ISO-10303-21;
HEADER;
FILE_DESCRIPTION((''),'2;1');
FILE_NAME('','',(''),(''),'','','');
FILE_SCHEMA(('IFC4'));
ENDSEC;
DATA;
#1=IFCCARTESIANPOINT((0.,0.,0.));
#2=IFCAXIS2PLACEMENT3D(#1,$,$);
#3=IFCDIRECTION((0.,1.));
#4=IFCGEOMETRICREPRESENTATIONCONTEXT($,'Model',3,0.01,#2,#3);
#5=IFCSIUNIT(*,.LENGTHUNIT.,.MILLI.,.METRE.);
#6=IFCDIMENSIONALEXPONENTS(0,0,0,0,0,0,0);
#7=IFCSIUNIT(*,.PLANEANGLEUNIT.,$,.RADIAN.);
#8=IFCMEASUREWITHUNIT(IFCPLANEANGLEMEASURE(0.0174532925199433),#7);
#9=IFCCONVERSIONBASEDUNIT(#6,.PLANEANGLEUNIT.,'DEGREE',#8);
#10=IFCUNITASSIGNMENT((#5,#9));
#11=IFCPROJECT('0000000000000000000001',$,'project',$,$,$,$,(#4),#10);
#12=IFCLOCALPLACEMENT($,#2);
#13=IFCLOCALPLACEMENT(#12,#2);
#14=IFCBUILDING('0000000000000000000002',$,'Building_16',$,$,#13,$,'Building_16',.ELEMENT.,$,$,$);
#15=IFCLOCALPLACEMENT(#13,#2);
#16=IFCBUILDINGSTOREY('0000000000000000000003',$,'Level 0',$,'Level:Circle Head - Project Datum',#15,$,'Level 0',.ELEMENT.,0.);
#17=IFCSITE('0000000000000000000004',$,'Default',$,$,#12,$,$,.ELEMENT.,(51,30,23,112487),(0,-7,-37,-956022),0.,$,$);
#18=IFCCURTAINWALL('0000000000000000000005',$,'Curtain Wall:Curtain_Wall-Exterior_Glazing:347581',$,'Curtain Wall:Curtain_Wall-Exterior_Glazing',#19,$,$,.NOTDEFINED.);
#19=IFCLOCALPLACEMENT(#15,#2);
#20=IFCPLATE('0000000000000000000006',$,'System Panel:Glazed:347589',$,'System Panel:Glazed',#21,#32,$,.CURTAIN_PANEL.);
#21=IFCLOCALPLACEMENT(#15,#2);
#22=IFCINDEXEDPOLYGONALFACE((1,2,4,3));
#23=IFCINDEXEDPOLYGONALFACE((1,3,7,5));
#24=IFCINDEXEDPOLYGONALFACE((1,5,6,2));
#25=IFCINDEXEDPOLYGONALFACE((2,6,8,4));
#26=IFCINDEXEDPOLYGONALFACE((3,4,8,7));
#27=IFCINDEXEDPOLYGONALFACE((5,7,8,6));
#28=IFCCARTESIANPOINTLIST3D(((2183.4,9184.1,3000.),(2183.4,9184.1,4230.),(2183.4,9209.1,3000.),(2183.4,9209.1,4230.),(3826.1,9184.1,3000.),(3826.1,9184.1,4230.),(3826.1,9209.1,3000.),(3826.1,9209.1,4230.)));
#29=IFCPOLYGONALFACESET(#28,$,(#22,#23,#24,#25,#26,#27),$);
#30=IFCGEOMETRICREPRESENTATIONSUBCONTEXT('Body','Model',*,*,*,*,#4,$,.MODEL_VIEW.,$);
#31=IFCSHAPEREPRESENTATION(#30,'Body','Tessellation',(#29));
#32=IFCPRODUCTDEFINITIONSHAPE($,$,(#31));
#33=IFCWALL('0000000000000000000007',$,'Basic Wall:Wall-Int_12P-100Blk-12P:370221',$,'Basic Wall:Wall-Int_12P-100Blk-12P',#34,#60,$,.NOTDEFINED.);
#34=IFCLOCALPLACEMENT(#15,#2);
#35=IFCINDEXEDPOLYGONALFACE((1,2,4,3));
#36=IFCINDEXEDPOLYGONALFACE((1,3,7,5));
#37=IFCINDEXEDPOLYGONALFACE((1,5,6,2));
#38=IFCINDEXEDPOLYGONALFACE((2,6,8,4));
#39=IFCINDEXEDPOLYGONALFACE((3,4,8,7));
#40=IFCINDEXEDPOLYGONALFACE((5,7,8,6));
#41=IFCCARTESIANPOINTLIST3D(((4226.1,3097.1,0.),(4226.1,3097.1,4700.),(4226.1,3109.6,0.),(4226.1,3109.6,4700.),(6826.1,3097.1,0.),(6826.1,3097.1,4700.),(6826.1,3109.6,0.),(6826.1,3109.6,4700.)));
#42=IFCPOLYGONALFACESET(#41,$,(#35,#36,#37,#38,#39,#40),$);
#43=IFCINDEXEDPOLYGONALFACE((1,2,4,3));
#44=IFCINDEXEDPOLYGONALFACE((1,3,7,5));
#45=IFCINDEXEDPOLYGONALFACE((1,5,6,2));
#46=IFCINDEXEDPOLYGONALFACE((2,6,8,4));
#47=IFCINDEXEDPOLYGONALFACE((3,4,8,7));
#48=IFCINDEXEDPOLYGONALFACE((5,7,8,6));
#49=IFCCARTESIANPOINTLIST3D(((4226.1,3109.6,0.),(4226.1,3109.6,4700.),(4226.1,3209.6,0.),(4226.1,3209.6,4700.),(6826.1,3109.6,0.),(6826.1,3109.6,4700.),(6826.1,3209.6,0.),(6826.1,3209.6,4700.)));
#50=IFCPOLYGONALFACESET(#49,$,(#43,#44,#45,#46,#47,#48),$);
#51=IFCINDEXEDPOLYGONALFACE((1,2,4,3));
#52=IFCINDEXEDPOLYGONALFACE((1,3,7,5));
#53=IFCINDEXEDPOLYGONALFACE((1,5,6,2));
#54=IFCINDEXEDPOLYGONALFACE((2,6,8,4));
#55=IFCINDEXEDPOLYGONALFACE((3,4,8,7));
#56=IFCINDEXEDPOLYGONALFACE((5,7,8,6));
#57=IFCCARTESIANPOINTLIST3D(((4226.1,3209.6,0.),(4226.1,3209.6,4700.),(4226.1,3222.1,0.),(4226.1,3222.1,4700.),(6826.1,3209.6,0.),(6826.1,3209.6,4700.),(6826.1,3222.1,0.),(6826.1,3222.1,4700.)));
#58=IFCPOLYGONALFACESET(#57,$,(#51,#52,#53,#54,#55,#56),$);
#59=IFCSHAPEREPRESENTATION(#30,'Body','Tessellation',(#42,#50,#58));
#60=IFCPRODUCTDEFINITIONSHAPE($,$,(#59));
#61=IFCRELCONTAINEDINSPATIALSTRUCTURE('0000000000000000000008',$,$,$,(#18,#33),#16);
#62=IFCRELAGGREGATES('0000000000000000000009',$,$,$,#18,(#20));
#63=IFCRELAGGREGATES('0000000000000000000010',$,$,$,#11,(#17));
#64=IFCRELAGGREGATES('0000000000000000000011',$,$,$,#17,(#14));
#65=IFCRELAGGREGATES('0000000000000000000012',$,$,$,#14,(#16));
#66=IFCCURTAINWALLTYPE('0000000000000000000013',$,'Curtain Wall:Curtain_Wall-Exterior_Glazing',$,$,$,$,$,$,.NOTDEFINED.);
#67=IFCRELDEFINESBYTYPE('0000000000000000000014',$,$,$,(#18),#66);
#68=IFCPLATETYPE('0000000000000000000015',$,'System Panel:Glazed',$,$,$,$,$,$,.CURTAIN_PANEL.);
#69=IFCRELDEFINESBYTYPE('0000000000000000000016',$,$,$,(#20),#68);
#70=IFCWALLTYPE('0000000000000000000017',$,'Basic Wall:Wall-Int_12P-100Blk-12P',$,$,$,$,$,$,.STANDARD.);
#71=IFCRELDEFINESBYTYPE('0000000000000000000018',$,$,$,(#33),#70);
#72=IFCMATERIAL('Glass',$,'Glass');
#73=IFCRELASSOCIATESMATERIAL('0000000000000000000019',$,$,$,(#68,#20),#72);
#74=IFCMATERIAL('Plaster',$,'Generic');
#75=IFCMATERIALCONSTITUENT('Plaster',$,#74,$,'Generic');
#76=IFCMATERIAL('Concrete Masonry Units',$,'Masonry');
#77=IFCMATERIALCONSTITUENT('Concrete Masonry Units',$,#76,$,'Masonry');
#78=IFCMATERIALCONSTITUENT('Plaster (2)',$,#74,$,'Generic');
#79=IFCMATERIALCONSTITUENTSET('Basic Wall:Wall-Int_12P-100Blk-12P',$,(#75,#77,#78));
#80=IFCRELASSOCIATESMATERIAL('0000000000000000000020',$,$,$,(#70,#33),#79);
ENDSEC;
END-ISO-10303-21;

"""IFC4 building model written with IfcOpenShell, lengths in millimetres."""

from ifc_helpers import new_model, entity, si_unit, converted_unit, direction, frame, origin, place, context, subcontext, project, spatial, indexed_curve, outline, extrude, source, transform, mapped, material, constituent, constituent_set, type_object, type_shapes, element, aggregate, save


model = new_model("IFC4")

# Units and contexts
model_context = context("Model", 3, precision=0.01, world=origin(), true_north=direction((0.0, 1.0)))
body_context = subcontext(model_context, "Body", "Model", "MODEL_VIEW")
ifc_project = project(units=[si_unit("LENGTHUNIT", "METRE", prefix="MILLI"), converted_unit("PLANEANGLEUNIT", "DEGREE", entity("IfcPlaneAngleMeasure", 0.0174532925199433), si_unit("PLANEANGLEUNIT", "RADIAN"), dimensions=[0, 0, 0, 0, 0, 0, 0])], contexts=[model_context])

# Site, building, storey
site_placement = place(None, origin())
site = spatial("IfcSite", under=ifc_project, at=site_placement, Name="Default", CompositionType="ELEMENT", RefLatitude=(51, 30, 23, 112487), RefLongitude=(0, -7, -37, -956022), RefElevation=0.0)
building_placement = place(site_placement, origin())
building = spatial("IfcBuilding", under=site, at=building_placement, Name="Building_16", LongName="Building_16", CompositionType="ELEMENT")
storey_placement = place(building_placement, origin())
storey = spatial("IfcBuildingStorey", under=building, at=storey_placement, Name="Level 0", ObjectType="Level:Circle Head - Project Datum", LongName="Level 0", CompositionType="ELEMENT", Elevation=0.0)

# Shared definitions
curtain_wall_type = type_object("IfcCurtainWallType", Name="Curtain Wall:Curtain_Wall-Exterior_Glazing", PredefinedType="NOTDEFINED")
ifc_material_1 = material(Name="Glass", Category="Glass")

# Curtain wall, plate
curtain_wall_1_placement = place(storey_placement, origin())
curtain_wall_1 = element("IfcCurtainWall", 1, at=curtain_wall_1_placement, inside=storey, type_object=curtain_wall_type, Name="Curtain Wall:Curtain_Wall-Exterior_Glazing:347581", ObjectType="Curtain Wall:Curtain_Wall-Exterior_Glazing", PredefinedType="NOTDEFINED")
plate_type_1 = type_object("IfcPlateType", Name="System Panel:Glazed", PredefinedType="CURTAIN_PANEL", material=ifc_material_1)
shared_shape_1 = source(origin(), body_context, "Body", "SweptSolid", [
    extrude(outline(indexed_curve([(-12.5, -821.4), (12.5, -821.4), (12.5, 821.4), (-12.5, 821.4), (-12.5, -821.4)], self_intersect=False)), frame((0.0, 37.0, 0.0), z_axis=(0.0, 0.0, 1.0), x_axis=(0.0, 1.0, 0.0)), (0.0, 0.0, 1.0), 1230.0),
])
type_shapes(plate_type_1, [shared_shape_1])
plate_1_placement = place(curtain_wall_1_placement, frame((3004.7, 9159.6, 3000.0)))
plate_1 = element("IfcPlate", 2, at=plate_1_placement, type_object=plate_type_1, material=ifc_material_1, Name="System Panel:Glazed:347589", ObjectType="System Panel:Glazed", PredefinedType="CURTAIN_PANEL", context=body_context, shape_type="MappedRepresentation", body=[
    mapped(shared_shape_1, transform((0.0, 0.0, 0.0), scale=1.0)),
])
aggregate(curtain_wall_1, [plate_1])

# Shared definitions
ifc_material_2 = material(Name="Concrete Masonry Units", Category="Masonry")
ifc_material_3 = material(Name="Plaster", Category="Generic")

# Shared definitions
ifc_constituent_1 = constituent(ifc_material_3, Name="Plaster", Category="Generic")
ifc_constituent_2 = constituent(ifc_material_2, Name="Concrete Masonry Units", Category="Masonry")
ifc_constituent_3 = constituent(ifc_material_3, Name="Plaster (2)", Category="Generic")
ifc_constituent_set_1 = constituent_set(constituents=[ifc_constituent_1, ifc_constituent_2, ifc_constituent_3], Name="Basic Wall:Wall-Int_12P-100Blk-12P")
wall_type_1 = type_object("IfcWallType", Name="Basic Wall:Wall-Int_12P-100Blk-12P", PredefinedType="STANDARD", material=ifc_constituent_set_1)

# Wall
wall_1_placement = place(storey_placement, frame((4226.1, 3159.6, 0.0)))
element("IfcWall", 3, at=wall_1_placement, inside=storey, type_object=wall_type_1, material=ifc_constituent_set_1, Name="Basic Wall:Wall-Int_12P-100Blk-12P:370221", ObjectType="Basic Wall:Wall-Int_12P-100Blk-12P", PredefinedType="NOTDEFINED", context=body_context, shape_type="SweptSolid", body=[
    extrude(outline(indexed_curve([(-6.3, -1300.0), (6.2, -1300.0), (6.3, 1300.0), (-6.2, 1300.0), (-6.3, -1300.0)], self_intersect=False)), frame((1300.0, -56.3, 0.0), z_axis=(0.0, 0.0, 1.0), x_axis=(0.0, 1.0, 0.0)), (0.0, 0.0, 1.0), 4700.0),
    extrude(outline(indexed_curve([(-1300.0, -50.0), (1300.0, -50.0), (1300.0, 50.0), (-1300.0, 50.0), (-1300.0, -50.0)], self_intersect=False)), frame((1300.0, 0.0, 0.0)), (0.0, 0.0, 1.0), 4700.0),
    extrude(outline(indexed_curve([(-6.3, -1300.0), (6.2, -1300.0), (6.3, 1300.0), (-6.2, 1300.0), (-6.3, -1300.0)], self_intersect=False)), frame((1300.0, 56.3, 0.0), z_axis=(0.0, 0.0, 1.0), x_axis=(0.0, -1.0, 0.0)), (0.0, 0.0, 1.0), 4700.0),
])

save(model, "model.ifc")
